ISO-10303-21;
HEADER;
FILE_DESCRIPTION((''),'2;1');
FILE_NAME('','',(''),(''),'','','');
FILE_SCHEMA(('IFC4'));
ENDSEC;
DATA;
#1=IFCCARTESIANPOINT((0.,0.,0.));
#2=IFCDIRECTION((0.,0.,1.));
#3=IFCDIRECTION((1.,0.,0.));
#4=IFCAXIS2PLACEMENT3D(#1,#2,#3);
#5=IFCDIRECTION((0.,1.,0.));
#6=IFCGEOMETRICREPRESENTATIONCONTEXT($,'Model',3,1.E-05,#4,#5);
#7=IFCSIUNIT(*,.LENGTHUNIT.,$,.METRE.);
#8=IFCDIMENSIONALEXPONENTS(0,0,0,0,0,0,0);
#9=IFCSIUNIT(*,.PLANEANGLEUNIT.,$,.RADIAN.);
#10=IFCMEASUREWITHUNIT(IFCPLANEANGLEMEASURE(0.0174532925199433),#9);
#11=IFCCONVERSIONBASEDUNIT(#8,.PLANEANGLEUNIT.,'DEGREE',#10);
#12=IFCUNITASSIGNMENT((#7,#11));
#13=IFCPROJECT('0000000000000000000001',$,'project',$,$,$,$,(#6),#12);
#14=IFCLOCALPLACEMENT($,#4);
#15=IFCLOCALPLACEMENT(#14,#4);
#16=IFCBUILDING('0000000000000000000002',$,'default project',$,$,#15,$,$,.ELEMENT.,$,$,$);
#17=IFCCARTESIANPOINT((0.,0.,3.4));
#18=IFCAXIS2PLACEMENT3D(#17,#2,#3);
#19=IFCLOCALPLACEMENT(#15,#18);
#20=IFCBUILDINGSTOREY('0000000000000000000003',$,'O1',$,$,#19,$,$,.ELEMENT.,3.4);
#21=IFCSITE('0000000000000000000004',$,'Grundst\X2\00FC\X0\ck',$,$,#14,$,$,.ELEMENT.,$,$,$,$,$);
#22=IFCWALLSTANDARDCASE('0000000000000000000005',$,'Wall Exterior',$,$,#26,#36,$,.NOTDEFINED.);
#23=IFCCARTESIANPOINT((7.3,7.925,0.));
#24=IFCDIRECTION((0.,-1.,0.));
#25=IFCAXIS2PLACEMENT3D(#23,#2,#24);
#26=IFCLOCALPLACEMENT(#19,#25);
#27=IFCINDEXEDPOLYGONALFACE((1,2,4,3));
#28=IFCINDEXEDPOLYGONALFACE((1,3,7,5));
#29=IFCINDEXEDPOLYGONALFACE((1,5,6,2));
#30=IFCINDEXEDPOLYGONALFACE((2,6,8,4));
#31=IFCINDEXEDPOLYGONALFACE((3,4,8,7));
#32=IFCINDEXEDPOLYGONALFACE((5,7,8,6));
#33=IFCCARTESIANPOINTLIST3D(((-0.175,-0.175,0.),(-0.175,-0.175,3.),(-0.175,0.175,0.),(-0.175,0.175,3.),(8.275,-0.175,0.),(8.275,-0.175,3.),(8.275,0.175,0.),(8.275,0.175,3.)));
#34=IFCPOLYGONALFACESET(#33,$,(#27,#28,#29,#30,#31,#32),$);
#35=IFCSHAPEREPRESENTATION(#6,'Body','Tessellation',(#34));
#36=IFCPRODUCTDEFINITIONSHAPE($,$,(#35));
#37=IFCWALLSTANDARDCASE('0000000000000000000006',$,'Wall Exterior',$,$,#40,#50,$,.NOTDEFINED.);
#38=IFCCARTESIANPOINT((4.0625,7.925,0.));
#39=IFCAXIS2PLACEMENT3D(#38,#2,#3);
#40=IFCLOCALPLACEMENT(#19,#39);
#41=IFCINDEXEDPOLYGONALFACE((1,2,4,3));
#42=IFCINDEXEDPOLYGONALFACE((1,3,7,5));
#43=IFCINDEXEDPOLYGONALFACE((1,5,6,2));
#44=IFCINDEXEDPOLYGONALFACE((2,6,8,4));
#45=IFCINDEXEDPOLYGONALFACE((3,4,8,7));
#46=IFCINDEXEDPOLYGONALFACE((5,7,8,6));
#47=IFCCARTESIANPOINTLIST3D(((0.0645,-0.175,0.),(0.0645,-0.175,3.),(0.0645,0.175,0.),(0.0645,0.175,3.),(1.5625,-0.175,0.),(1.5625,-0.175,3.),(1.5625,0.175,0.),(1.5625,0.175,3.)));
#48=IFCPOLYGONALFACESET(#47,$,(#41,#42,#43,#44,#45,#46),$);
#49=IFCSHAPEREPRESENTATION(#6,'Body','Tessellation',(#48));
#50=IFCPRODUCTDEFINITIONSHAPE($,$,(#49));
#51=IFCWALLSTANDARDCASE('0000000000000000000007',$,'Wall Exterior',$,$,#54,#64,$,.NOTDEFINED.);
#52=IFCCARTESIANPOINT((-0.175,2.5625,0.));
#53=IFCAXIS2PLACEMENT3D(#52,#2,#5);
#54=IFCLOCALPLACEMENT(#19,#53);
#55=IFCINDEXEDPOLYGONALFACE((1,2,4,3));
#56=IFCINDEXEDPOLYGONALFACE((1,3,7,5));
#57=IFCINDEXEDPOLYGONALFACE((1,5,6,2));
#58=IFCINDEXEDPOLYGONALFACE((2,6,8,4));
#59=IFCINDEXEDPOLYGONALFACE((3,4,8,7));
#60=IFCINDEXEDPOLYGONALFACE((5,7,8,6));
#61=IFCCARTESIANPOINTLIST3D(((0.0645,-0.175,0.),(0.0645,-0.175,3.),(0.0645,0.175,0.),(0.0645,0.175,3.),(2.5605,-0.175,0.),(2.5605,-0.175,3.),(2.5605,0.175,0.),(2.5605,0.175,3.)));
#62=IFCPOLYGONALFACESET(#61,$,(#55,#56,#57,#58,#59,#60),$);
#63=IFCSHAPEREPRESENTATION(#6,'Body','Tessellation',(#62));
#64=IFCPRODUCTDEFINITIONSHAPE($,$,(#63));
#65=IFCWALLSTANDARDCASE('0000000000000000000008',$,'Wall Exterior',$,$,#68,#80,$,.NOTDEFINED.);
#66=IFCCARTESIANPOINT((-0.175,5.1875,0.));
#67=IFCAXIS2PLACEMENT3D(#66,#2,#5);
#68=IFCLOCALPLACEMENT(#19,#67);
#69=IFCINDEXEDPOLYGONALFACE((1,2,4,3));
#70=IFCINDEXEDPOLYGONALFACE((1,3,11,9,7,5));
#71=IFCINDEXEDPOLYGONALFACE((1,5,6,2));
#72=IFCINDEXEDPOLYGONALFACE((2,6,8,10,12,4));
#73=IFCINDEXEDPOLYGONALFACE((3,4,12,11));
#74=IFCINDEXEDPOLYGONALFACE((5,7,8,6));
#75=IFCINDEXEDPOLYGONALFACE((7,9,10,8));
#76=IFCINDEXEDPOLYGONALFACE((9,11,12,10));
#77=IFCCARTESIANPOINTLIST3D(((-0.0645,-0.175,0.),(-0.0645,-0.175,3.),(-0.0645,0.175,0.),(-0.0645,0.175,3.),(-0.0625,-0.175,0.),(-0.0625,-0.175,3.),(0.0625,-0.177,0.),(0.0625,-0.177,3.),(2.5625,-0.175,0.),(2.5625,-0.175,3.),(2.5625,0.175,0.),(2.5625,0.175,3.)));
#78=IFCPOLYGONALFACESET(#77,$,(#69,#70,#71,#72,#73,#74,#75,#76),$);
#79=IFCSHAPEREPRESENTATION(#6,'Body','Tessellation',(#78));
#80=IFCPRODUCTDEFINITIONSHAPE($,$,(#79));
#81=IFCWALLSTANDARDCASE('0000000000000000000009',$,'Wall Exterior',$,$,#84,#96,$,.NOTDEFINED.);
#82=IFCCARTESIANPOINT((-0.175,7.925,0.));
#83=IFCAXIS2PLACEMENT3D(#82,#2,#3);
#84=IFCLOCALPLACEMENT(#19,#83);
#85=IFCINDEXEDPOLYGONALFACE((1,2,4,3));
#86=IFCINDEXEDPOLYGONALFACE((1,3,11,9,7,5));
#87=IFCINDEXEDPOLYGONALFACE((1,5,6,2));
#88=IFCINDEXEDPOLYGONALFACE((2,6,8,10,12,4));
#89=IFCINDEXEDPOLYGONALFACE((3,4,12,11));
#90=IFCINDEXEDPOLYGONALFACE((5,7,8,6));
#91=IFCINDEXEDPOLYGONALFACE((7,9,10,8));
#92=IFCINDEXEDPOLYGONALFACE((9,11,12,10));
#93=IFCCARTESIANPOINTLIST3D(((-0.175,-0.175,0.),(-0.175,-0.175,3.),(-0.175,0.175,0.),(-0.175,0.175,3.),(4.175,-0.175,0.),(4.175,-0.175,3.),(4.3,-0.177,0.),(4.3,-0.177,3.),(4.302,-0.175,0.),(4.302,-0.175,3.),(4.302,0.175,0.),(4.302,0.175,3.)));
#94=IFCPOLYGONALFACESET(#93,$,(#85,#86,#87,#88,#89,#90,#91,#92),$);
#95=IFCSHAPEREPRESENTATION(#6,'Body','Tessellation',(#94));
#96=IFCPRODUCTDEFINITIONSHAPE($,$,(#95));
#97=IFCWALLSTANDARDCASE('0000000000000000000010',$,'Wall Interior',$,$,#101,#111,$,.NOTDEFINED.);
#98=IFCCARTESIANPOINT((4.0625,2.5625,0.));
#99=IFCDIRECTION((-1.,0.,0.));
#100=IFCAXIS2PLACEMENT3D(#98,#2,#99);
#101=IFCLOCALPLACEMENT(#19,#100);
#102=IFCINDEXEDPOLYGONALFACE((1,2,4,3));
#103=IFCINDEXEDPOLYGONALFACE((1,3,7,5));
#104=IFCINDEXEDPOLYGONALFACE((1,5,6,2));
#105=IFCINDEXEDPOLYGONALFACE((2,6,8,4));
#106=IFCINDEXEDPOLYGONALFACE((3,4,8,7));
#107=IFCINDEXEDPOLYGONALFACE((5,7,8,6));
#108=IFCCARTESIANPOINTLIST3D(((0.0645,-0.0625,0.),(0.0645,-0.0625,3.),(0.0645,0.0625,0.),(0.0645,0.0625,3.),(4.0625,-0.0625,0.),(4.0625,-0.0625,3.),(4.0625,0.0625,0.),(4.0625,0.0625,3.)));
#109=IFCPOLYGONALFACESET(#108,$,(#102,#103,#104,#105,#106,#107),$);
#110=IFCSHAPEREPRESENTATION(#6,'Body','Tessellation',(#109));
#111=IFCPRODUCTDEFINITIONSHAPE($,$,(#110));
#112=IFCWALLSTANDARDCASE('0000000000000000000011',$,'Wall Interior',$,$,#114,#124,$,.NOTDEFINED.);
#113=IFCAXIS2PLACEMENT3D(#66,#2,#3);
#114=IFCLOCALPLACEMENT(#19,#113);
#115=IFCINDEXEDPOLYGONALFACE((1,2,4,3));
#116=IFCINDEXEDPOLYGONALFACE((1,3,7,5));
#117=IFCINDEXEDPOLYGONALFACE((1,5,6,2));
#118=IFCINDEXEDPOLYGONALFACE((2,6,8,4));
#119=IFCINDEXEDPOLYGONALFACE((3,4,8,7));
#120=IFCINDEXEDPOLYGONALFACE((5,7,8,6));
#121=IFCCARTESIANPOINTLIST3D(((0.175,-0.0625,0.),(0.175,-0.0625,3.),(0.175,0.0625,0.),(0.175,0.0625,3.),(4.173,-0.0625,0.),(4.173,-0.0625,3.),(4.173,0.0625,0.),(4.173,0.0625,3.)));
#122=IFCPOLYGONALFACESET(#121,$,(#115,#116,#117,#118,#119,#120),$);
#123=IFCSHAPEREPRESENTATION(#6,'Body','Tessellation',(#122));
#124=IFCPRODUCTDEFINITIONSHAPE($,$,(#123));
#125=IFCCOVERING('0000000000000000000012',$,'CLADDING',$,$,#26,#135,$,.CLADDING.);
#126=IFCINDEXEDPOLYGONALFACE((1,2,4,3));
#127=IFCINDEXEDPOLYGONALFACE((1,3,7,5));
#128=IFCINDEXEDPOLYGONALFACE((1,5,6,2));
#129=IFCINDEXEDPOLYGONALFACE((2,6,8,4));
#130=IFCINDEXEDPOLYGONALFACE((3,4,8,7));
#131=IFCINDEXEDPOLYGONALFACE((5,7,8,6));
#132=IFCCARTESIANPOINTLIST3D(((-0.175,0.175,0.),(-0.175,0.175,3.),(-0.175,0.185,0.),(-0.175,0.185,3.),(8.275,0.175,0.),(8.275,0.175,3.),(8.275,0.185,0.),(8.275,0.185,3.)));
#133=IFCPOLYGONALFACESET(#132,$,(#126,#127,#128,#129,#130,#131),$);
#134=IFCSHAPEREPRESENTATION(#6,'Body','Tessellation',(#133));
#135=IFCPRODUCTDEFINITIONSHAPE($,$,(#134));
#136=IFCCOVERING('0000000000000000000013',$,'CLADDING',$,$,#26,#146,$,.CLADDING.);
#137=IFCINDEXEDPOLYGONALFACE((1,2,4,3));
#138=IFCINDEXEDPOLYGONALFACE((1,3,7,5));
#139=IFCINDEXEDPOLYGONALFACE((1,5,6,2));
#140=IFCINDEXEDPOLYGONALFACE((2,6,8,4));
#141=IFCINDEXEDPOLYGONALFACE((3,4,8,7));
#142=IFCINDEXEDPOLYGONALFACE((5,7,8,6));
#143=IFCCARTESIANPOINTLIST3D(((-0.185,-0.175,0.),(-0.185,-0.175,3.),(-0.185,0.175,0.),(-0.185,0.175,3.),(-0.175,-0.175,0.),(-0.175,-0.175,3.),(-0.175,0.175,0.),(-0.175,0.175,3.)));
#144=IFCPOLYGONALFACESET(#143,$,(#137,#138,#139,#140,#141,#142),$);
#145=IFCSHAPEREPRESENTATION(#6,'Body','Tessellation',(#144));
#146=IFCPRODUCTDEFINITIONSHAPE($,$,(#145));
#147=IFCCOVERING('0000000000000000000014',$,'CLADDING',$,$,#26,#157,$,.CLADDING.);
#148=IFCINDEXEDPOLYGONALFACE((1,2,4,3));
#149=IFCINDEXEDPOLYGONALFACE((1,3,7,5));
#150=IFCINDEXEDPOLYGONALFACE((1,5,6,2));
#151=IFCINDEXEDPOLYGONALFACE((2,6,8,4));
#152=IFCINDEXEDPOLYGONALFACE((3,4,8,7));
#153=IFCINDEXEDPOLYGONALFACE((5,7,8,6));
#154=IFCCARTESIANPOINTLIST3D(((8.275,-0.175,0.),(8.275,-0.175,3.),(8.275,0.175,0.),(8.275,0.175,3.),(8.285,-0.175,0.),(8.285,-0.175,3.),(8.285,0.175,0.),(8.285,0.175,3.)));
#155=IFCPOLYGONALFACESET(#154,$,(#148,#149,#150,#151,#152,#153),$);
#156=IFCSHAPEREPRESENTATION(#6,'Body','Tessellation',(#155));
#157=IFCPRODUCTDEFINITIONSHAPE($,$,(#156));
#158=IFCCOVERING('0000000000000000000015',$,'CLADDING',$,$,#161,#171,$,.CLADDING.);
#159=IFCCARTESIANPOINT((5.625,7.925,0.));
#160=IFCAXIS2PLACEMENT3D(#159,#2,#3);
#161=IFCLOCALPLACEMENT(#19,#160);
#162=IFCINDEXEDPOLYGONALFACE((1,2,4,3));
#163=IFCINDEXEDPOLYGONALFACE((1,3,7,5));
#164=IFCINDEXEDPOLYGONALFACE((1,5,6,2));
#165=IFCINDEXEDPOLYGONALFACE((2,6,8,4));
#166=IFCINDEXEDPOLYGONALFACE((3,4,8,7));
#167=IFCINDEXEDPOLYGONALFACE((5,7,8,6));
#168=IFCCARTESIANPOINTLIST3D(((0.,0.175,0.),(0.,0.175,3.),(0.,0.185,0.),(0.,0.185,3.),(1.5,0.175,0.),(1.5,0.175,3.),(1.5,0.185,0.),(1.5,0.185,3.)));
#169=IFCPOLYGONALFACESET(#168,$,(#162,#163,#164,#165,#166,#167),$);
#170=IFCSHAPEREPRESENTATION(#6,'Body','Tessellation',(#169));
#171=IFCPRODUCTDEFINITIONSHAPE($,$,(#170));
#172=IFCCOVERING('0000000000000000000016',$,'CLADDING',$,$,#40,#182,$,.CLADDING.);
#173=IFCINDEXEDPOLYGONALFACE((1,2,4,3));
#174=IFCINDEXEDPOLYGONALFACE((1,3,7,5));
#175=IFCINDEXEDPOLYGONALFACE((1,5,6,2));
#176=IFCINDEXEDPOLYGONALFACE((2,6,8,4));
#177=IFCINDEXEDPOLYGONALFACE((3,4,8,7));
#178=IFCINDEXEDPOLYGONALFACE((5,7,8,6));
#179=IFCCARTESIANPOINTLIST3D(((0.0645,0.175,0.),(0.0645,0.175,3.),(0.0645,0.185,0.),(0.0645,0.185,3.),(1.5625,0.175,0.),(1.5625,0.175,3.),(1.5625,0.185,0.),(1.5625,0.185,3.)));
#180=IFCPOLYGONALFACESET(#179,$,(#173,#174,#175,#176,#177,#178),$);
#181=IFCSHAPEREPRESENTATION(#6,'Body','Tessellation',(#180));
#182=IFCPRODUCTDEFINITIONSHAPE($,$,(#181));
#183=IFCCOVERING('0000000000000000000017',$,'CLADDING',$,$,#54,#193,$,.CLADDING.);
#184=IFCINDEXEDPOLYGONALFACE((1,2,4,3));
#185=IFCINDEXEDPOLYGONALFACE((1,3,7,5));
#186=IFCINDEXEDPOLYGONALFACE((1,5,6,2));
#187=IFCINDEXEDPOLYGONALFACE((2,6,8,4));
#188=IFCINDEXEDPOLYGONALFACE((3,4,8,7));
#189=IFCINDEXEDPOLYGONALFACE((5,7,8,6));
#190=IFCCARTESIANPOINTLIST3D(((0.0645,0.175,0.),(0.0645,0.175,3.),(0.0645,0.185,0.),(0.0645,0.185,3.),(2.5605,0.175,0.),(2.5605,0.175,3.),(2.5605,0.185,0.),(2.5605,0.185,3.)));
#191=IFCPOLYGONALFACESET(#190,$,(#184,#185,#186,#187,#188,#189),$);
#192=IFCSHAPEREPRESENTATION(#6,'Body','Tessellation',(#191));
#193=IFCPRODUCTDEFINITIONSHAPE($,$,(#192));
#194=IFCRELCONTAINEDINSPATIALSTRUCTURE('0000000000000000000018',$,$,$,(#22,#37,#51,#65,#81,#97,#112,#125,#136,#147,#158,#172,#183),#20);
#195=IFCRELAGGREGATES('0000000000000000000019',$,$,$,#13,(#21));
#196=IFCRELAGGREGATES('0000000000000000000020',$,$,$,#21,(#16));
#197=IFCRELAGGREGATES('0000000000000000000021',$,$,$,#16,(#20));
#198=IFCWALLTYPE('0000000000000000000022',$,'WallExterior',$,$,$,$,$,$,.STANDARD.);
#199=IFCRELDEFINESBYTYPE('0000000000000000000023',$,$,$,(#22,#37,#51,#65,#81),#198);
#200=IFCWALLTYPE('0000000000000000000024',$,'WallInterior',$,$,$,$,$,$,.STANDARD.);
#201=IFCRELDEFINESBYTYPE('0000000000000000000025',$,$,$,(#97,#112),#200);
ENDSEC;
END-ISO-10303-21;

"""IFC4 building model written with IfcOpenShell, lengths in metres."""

from ifc_helpers import new_model, entity, si_unit, converted_unit, direction, frame, origin_with_axes, place, context, project, spatial, polyline, outline, extrude, type_object, element, save


model = new_model("IFC4")

# Units and contexts
model_context = context("Model", 3, precision=1e-05, world=origin_with_axes(), true_north=direction((0.0, 1.0, 0.0)))
ifc_project = project(units=[si_unit("LENGTHUNIT", "METRE"), converted_unit("PLANEANGLEUNIT", "DEGREE", entity("IfcPlaneAngleMeasure", 0.0174532925199433), si_unit("PLANEANGLEUNIT", "RADIAN"), dimensions=[0, 0, 0, 0, 0, 0, 0])], contexts=[model_context])

# Site, building, storey
site_placement = place(None, origin_with_axes())
site = spatial("IfcSite", under=ifc_project, at=site_placement, Name="Grundstück", CompositionType="ELEMENT")
building_placement = place(site_placement, origin_with_axes())
building = spatial("IfcBuilding", under=site, at=building_placement, Name="default project", CompositionType="ELEMENT")
placement_1 = place(building_placement, frame((0.0, 0.0, 3.4), z_axis=(0.0, 0.0, 1.0), x_axis=(1.0, 0.0, 0.0)))
storey = spatial("IfcBuildingStorey", under=building, at=placement_1, Name="O1", CompositionType="ELEMENT", Elevation=3.4)

# Walls
wall_type_1 = type_object("IfcWallType", Name="WallExterior", PredefinedType="STANDARD")
placement_2 = place(placement_1, frame((7.3, 7.925, 0.0), z_axis=(0.0, 0.0, 1.0), x_axis=(0.0, -1.0, 0.0)))
element("IfcWallStandardCase", 1, at=placement_2, inside=storey, type_object=wall_type_1, Name="Wall Exterior", PredefinedType="NOTDEFINED", context=model_context, shape_type="SweptSolid", body=[
    extrude(outline(polyline([(8.275, 0.175), (-0.175, 0.175), (-0.175, -0.175), (8.275, -0.175), (8.275, 0.175)])), origin_with_axes(), (0.0, 0.0, 1.0), 3.0),
])
placement_3 = place(placement_1, frame((5.625, 7.925, 0.0), z_axis=(0.0, 0.0, 1.0), x_axis=(1.0, 0.0, 0.0)))
placement_4 = place(placement_1, frame((4.0625, 7.925, 0.0), z_axis=(0.0, 0.0, 1.0), x_axis=(1.0, 0.0, 0.0)))
element("IfcWallStandardCase", 2, at=placement_4, inside=storey, type_object=wall_type_1, Name="Wall Exterior", PredefinedType="NOTDEFINED", context=model_context, shape_type="SweptSolid", body=[
    extrude(outline(polyline([(1.5625, 0.175), (0.0645, 0.175), (0.0645, -0.175), (1.5625, -0.175), (1.5625, 0.175)])), origin_with_axes(), (0.0, 0.0, 1.0), 3.0),
])
placement_5 = place(placement_1, frame((-0.175, 2.5625, 0.0), z_axis=(0.0, 0.0, 1.0), x_axis=(0.0, 1.0, 0.0)))
element("IfcWallStandardCase", 3, at=placement_5, inside=storey, type_object=wall_type_1, Name="Wall Exterior", PredefinedType="NOTDEFINED", context=model_context, shape_type="SweptSolid", body=[
    extrude(outline(polyline([(0.0645, -0.175), (2.5605, -0.175), (2.5605, 0.175), (0.0645, 0.175), (0.0645, -0.175)])), origin_with_axes(), (0.0, 0.0, 1.0), 3.0),
])
placement_6 = place(placement_1, frame((-0.175, 5.1875, 0.0), z_axis=(0.0, 0.0, 1.0), x_axis=(0.0, 1.0, 0.0)))
element("IfcWallStandardCase", 4, at=placement_6, inside=storey, type_object=wall_type_1, Name="Wall Exterior", PredefinedType="NOTDEFINED", context=model_context, shape_type="SweptSolid", body=[
    extrude(outline(polyline([(-0.0625, -0.175), (0.0625, -0.177), (2.5625, -0.175), (2.5625, 0.175), (-0.0645, 0.175), (-0.0645, -0.175), (-0.0625, -0.175)])), origin_with_axes(), (0.0, 0.0, 1.0), 3.0),
])
placement_7 = place(placement_1, frame((-0.175, 7.925, 0.0), z_axis=(0.0, 0.0, 1.0), x_axis=(1.0, 0.0, 0.0)))
element("IfcWallStandardCase", 5, at=placement_7, inside=storey, type_object=wall_type_1, Name="Wall Exterior", PredefinedType="NOTDEFINED", context=model_context, shape_type="SweptSolid", body=[
    extrude(outline(polyline([(-0.175, 0.175), (-0.175, -0.175), (4.175, -0.175), (4.3, -0.177), (4.302, -0.175), (4.302, 0.175), (-0.175, 0.175)])), origin_with_axes(), (0.0, 0.0, 1.0), 3.0),
])
wall_type_2 = type_object("IfcWallType", Name="WallInterior", PredefinedType="STANDARD")
wall_1_placement = place(placement_1, frame((4.0625, 2.5625, 0.0), z_axis=(0.0, 0.0, 1.0), x_axis=(-1.0, 0.0, 0.0)))
element("IfcWallStandardCase", 6, at=wall_1_placement, inside=storey, type_object=wall_type_2, Name="Wall Interior", PredefinedType="NOTDEFINED", context=model_context, shape_type="SweptSolid", body=[
    extrude(outline(polyline([(0.0645, -0.0625), (4.0625, -0.0625), (4.0625, 0.0625), (0.0645, 0.0625), (0.0645, -0.0625)])), origin_with_axes(), (0.0, 0.0, 1.0), 3.0),
])
wall_2_placement = place(placement_1, frame((-0.175, 5.1875, 0.0), z_axis=(0.0, 0.0, 1.0), x_axis=(1.0, 0.0, 0.0)))
element("IfcWallStandardCase", 7, at=wall_2_placement, inside=storey, type_object=wall_type_2, Name="Wall Interior", PredefinedType="NOTDEFINED", context=model_context, shape_type="SweptSolid", body=[
    extrude(outline(polyline([(4.173, 0.0625), (0.175, 0.0625), (0.175, -0.0625), (4.173, -0.0625), (4.173, 0.0625)])), origin_with_axes(), (0.0, 0.0, 1.0), 3.0),
])

# Coverings
element("IfcCovering", 8, at=placement_2, inside=storey, Name="CLADDING", PredefinedType="CLADDING", context=model_context, shape_type="SweptSolid", body=[
    extrude(outline(polyline([(8.275, 0.185), (-0.175, 0.185), (-0.175, 0.175), (8.275, 0.175), (8.275, 0.185)])), origin_with_axes(), (0.0, 0.0, 1.0), 3.0),
])
element("IfcCovering", 9, at=placement_2, inside=storey, Name="CLADDING", PredefinedType="CLADDING", context=model_context, shape_type="SweptSolid", body=[
    extrude(outline(polyline([(-0.185, 0.175), (-0.185, -0.175), (-0.175, -0.175), (-0.175, 0.175), (-0.185, 0.175)])), origin_with_axes(), (0.0, 0.0, 1.0), 3.0),
])
element("IfcCovering", 10, at=placement_2, inside=storey, Name="CLADDING", PredefinedType="CLADDING", context=model_context, shape_type="SweptSolid", body=[
    extrude(outline(polyline([(8.285, -0.175), (8.285, 0.175), (8.275, 0.175), (8.275, -0.175), (8.285, -0.175)])), origin_with_axes(), (0.0, 0.0, 1.0), 3.0),
])
element("IfcCovering", 11, at=placement_3, inside=storey, Name="CLADDING", PredefinedType="CLADDING", context=model_context, shape_type="SweptSolid", body=[
    extrude(outline(polyline([(1.5, 0.185), (0.0, 0.185), (0.0, 0.175), (1.5, 0.175), (1.5, 0.185)])), origin_with_axes(), (0.0, 0.0, 1.0), 3.0),
])
element("IfcCovering", 12, at=placement_4, inside=storey, Name="CLADDING", PredefinedType="CLADDING", context=model_context, shape_type="SweptSolid", body=[
    extrude(outline(polyline([(1.5625, 0.185), (0.0645, 0.185), (0.0645, 0.175), (1.5625, 0.175), (1.5625, 0.185)])), origin_with_axes(), (0.0, 0.0, 1.0), 3.0),
])
element("IfcCovering", 13, at=placement_5, inside=storey, Name="CLADDING", PredefinedType="CLADDING", context=model_context, shape_type="SweptSolid", body=[
    extrude(outline(polyline([(2.5605, 0.185), (0.0645, 0.185), (0.0645, 0.175), (2.5605, 0.175), (2.5605, 0.185)])), origin_with_axes(), (0.0, 0.0, 1.0), 3.0),
])

save(model, "model.ifc")
